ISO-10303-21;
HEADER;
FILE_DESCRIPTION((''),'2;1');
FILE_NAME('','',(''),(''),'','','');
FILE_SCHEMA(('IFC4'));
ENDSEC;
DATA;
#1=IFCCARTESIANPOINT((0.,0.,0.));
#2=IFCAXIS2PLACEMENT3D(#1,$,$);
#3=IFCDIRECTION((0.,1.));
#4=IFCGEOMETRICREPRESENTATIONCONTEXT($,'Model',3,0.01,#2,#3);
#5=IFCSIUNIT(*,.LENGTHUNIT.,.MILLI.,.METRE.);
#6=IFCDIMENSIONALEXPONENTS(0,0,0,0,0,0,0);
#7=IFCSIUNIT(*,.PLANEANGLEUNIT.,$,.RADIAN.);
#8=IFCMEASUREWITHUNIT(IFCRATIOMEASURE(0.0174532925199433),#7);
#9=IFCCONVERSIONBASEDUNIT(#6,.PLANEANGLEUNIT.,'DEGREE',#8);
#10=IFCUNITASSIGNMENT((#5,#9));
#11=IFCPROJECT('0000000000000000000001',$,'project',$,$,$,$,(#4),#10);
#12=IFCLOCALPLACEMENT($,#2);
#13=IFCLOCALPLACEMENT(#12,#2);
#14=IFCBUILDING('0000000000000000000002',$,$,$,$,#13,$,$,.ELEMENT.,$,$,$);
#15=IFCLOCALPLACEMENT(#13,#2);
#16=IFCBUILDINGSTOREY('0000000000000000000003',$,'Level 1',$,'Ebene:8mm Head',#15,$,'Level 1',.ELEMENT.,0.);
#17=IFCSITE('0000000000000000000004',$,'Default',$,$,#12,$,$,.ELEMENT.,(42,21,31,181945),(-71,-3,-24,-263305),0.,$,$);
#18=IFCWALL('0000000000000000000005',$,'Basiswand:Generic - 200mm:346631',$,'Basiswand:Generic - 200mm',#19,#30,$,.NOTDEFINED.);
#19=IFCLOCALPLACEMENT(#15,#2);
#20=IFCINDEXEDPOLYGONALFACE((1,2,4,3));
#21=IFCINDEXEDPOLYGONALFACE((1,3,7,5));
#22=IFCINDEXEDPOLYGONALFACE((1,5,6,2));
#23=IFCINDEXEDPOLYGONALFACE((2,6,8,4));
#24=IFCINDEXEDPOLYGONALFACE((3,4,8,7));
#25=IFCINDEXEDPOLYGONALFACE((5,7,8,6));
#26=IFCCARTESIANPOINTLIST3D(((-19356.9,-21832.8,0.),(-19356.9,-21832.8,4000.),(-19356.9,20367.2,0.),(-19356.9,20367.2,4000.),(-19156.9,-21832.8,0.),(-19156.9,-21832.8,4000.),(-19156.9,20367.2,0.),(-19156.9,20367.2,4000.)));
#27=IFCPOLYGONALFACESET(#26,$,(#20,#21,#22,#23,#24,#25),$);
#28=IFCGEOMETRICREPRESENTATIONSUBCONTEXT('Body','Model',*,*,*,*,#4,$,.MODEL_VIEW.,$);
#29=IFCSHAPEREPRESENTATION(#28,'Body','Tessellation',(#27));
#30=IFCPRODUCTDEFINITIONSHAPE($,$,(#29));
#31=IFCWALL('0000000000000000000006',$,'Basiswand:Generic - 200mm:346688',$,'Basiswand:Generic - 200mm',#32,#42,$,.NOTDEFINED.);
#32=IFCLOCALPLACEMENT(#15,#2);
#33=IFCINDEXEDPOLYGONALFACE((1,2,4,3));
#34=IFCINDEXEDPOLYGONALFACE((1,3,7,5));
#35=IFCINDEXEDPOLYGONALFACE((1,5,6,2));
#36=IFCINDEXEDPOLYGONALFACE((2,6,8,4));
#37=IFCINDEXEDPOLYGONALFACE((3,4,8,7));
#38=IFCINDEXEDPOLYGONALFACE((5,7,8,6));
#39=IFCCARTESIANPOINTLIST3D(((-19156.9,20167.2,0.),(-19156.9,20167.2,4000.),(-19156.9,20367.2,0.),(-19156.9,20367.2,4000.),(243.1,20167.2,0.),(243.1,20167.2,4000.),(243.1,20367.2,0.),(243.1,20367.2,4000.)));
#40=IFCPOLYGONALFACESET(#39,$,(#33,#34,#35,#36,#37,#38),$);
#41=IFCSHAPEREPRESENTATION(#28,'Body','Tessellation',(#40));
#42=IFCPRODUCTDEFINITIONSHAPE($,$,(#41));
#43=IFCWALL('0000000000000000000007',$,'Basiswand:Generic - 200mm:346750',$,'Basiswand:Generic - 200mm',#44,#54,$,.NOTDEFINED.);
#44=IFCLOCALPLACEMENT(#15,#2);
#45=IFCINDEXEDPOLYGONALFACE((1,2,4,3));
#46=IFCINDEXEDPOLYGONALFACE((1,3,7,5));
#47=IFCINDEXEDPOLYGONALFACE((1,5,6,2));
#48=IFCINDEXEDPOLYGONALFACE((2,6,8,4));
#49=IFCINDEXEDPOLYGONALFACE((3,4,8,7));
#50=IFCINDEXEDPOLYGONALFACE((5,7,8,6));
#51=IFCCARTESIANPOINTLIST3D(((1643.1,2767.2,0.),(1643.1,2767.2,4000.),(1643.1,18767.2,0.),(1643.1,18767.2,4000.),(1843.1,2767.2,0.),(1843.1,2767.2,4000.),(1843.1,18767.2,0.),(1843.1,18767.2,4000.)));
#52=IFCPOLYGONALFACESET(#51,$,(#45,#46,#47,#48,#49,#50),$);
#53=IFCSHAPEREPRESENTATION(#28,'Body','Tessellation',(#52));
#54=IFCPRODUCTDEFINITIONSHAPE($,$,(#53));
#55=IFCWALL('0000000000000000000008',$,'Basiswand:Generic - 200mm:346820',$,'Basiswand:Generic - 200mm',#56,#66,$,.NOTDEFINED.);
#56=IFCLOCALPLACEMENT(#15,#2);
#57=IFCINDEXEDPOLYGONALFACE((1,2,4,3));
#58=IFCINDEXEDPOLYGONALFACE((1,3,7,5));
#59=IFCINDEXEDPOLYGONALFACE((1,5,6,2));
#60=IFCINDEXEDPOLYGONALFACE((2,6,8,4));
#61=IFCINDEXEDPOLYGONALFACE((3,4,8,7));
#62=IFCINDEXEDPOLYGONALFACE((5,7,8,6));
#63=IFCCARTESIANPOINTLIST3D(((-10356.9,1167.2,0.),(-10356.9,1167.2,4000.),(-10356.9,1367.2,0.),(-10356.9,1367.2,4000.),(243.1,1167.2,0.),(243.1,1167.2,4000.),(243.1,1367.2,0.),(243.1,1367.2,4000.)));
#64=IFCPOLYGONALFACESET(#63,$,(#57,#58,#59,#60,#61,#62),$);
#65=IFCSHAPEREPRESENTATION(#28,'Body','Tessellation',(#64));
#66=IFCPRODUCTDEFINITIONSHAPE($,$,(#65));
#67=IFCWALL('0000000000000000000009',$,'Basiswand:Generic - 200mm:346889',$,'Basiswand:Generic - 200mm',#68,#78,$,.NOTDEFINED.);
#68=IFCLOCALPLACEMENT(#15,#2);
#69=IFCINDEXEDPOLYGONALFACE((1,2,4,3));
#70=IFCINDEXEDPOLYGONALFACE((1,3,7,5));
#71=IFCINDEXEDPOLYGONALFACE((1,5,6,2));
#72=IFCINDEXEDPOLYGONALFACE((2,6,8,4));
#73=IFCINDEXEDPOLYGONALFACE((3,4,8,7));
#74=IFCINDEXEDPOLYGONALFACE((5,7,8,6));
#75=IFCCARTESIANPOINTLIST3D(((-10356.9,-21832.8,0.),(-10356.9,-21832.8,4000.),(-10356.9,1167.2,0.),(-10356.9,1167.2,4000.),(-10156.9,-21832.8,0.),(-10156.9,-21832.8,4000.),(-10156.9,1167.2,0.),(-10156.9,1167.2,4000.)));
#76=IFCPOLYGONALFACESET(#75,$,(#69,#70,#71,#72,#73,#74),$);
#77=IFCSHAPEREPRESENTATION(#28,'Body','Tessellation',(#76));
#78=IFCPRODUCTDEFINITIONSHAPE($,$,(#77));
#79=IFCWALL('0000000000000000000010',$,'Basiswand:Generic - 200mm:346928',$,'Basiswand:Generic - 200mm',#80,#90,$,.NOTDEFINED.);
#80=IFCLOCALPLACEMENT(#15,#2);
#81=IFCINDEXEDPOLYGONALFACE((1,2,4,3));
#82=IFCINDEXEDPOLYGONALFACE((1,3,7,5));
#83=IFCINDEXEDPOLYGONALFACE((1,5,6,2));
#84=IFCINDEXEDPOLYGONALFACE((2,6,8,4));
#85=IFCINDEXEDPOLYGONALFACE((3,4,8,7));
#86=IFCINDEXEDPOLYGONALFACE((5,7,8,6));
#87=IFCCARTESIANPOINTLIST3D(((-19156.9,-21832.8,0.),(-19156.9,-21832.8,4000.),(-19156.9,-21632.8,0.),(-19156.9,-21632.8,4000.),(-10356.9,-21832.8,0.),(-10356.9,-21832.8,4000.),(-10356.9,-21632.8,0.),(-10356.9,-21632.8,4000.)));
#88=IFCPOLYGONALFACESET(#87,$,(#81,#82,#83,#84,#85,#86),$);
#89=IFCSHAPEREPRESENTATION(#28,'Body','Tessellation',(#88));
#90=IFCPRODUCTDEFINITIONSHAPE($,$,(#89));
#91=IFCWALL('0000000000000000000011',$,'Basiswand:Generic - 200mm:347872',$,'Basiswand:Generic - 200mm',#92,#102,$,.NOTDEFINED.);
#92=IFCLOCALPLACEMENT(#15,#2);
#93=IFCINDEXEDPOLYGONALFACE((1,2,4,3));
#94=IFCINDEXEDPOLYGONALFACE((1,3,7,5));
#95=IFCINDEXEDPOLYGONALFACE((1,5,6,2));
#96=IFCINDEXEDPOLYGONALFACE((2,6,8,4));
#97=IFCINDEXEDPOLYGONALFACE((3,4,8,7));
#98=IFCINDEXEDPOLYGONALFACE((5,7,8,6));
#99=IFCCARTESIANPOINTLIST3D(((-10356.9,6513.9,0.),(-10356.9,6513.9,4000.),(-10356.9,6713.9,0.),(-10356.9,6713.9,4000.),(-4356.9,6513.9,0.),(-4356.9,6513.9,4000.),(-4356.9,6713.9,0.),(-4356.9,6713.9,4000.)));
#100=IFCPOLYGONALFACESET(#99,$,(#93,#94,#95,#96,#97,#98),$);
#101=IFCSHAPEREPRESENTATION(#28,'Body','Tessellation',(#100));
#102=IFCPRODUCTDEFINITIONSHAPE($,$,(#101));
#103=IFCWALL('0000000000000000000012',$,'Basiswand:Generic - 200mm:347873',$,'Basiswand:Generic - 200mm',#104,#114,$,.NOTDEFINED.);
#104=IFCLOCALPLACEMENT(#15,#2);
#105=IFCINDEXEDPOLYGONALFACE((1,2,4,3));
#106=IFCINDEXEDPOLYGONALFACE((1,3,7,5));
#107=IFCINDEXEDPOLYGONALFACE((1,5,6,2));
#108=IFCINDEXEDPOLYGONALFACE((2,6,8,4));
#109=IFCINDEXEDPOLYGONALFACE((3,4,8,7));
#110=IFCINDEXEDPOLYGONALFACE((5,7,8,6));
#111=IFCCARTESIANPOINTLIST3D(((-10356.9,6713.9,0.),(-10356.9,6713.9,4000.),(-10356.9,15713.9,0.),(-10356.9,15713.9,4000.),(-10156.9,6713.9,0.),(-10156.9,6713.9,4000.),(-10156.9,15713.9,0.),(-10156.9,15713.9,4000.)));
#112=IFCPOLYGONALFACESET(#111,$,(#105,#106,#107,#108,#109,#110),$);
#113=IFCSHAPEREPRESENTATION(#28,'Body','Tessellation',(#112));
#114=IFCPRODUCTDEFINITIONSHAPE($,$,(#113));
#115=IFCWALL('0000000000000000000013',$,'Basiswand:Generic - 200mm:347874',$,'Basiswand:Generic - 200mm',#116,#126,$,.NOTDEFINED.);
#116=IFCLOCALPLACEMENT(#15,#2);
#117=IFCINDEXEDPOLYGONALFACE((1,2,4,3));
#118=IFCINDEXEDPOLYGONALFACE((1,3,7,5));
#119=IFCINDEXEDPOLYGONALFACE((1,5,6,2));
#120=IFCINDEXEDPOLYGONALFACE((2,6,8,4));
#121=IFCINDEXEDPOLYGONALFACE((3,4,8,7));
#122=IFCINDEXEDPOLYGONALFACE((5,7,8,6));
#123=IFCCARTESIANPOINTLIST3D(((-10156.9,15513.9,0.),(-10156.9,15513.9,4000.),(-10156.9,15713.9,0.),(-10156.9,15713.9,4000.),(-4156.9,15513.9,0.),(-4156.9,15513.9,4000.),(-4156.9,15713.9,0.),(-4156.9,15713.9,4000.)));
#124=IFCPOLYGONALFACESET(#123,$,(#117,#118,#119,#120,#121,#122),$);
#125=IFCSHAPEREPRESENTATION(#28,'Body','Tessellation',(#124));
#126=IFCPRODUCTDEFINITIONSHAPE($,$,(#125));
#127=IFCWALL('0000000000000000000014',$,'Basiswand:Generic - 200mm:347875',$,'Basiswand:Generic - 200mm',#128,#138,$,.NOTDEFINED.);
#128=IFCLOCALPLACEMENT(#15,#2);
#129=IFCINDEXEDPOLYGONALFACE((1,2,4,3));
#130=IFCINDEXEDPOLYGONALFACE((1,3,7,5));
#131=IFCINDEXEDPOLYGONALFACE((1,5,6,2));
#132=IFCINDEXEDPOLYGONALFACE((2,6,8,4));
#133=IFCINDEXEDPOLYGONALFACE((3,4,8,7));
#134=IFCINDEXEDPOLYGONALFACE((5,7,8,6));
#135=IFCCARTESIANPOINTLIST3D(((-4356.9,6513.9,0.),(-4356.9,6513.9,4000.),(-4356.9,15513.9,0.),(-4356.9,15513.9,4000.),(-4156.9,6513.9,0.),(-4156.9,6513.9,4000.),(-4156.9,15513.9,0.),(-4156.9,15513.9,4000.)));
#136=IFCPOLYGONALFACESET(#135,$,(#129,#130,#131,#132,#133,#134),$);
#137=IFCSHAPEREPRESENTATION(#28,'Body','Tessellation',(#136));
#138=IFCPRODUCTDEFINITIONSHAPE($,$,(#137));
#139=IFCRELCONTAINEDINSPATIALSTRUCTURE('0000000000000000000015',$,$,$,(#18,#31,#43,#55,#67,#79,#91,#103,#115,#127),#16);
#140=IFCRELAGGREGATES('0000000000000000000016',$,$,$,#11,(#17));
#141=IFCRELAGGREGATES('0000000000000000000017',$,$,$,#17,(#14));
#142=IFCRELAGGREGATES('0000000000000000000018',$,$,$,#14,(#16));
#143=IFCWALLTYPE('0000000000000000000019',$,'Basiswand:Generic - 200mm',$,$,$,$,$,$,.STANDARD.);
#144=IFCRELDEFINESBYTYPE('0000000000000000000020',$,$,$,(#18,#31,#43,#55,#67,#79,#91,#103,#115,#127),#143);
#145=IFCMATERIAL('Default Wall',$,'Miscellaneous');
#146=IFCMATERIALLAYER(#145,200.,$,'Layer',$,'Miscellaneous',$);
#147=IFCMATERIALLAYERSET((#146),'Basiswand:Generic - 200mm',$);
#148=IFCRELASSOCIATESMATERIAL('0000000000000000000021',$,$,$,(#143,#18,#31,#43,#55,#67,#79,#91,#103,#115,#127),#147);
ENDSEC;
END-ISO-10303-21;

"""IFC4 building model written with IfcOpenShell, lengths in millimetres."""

from ifc_helpers import new_model, entity, si_unit, converted_unit, direction, frame, frame_2d, origin, place, context, subcontext, project, spatial, rectangle, extrude, material, layer, layer_set, layer_usage, type_object, element, save


model = new_model("IFC4")

# Units and contexts
model_context = context("Model", 3, precision=0.01, world=origin(), true_north=direction((0.0, 1.0)))
body_context = subcontext(model_context, "Body", "Model", "MODEL_VIEW")
ifc_project = project(units=[si_unit("LENGTHUNIT", "METRE", prefix="MILLI"), converted_unit("PLANEANGLEUNIT", "DEGREE", entity("IfcRatioMeasure", 0.0174532925199433), si_unit("PLANEANGLEUNIT", "RADIAN"), dimensions=[0, 0, 0, 0, 0, 0, 0])], contexts=[model_context])

# Site, building, storey
site_placement = place(None, origin())
site = spatial("IfcSite", under=ifc_project, at=site_placement, Name="Default", CompositionType="ELEMENT", RefLatitude=(42, 21, 31, 181945), RefLongitude=(-71, -3, -24, -263305), RefElevation=0.0)
building_placement = place(site_placement, origin())
building = spatial("IfcBuilding", under=site, at=building_placement, CompositionType="ELEMENT")
storey_placement = place(building_placement, origin())
storey = spatial("IfcBuildingStorey", under=building, at=storey_placement, Name="Level 1", ObjectType="Ebene:8mm Head", LongName="Level 1", CompositionType="ELEMENT", Elevation=0.0)

# Walls
ifc_material = material(Name="Default Wall", Category="Miscellaneous")
ifc_layer = layer(ifc_material, 200.0, Name="Layer", Category="Miscellaneous")
ifc_layer_set = layer_set([ifc_layer], Name="Basiswand:Generic - 200mm")
ifc_layer_usage_1 = layer_usage(ifc_layer_set, "AXIS2", "NEGATIVE", 100.0)
wall_type = type_object("IfcWallType", Name="Basiswand:Generic - 200mm", PredefinedType="STANDARD", material=ifc_layer_set)
wall_1_placement = place(storey_placement, frame((-19256.9, -21832.8, 0.0), z_axis=(0.0, 0.0, 1.0), x_axis=(0.0, 1.0, 0.0)))
element("IfcWall", 1, at=wall_1_placement, inside=storey, type_object=wall_type, material=ifc_layer_usage_1, Name="Basiswand:Generic - 200mm:346631", ObjectType="Basiswand:Generic - 200mm", PredefinedType="NOTDEFINED", context=body_context, shape_type="SweptSolid", body=[
    extrude(rectangle(XDim=42200.0, YDim=200.0, at=frame_2d((21100.0, 0.0), x_axis=(-1.0, 0.0))), origin(), (0.0, 0.0, 1.0), 4000.0),
])
ifc_layer_usage_2 = layer_usage(ifc_layer_set, "AXIS2", "NEGATIVE", 100.0)
wall_2_placement = place(storey_placement, frame((-19156.9, 20267.2, 0.0)))
element("IfcWall", 2, at=wall_2_placement, inside=storey, type_object=wall_type, material=ifc_layer_usage_2, Name="Basiswand:Generic - 200mm:346688", ObjectType="Basiswand:Generic - 200mm", PredefinedType="NOTDEFINED", context=body_context, shape_type="SweptSolid", body=[
    extrude(rectangle(XDim=19400.0, YDim=200.0, at=frame_2d((9700.0, 0.0), x_axis=(-1.0, 0.0))), origin(), (0.0, 0.0, 1.0), 4000.0),
])
ifc_layer_usage_3 = layer_usage(ifc_layer_set, "AXIS2", "NEGATIVE", 100.0)
wall_3_placement = place(storey_placement, frame((1743.1, 18767.2, 0.0), z_axis=(0.0, 0.0, 1.0), x_axis=(0.0, -1.0, 0.0)))
element("IfcWall", 3, at=wall_3_placement, inside=storey, type_object=wall_type, material=ifc_layer_usage_3, Name="Basiswand:Generic - 200mm:346750", ObjectType="Basiswand:Generic - 200mm", PredefinedType="NOTDEFINED", context=body_context, shape_type="SweptSolid", body=[
    extrude(rectangle(XDim=16000.0, YDim=200.0, at=frame_2d((8000.0, 0.0), x_axis=(-1.0, 0.0))), origin(), (0.0, 0.0, 1.0), 4000.0),
])
ifc_layer_usage_4 = layer_usage(ifc_layer_set, "AXIS2", "NEGATIVE", 100.0)
wall_4_placement = place(storey_placement, frame((243.1, 1267.2, 0.0), z_axis=(0.0, 0.0, 1.0), x_axis=(-1.0, 0.0, 0.0)))
element("IfcWall", 4, at=wall_4_placement, inside=storey, type_object=wall_type, material=ifc_layer_usage_4, Name="Basiswand:Generic - 200mm:346820", ObjectType="Basiswand:Generic - 200mm", PredefinedType="NOTDEFINED", context=body_context, shape_type="SweptSolid", body=[
    extrude(rectangle(XDim=10600.0, YDim=200.0, at=frame_2d((5300.0, 0.0), x_axis=(-1.0, 0.0))), origin(), (0.0, 0.0, 1.0), 4000.0),
])
ifc_layer_usage_5 = layer_usage(ifc_layer_set, "AXIS2", "NEGATIVE", 100.0)
wall_5_placement = place(storey_placement, frame((-10256.9, 1167.2, 0.0), z_axis=(0.0, 0.0, 1.0), x_axis=(0.0, -1.0, 0.0)))
element("IfcWall", 5, at=wall_5_placement, inside=storey, type_object=wall_type, material=ifc_layer_usage_5, Name="Basiswand:Generic - 200mm:346889", ObjectType="Basiswand:Generic - 200mm", PredefinedType="NOTDEFINED", context=body_context, shape_type="SweptSolid", body=[
    extrude(rectangle(XDim=23000.0, YDim=200.0, at=frame_2d((11500.0, 0.0), x_axis=(-1.0, 0.0))), origin(), (0.0, 0.0, 1.0), 4000.0),
])
ifc_layer_usage_6 = layer_usage(ifc_layer_set, "AXIS2", "NEGATIVE", 100.0)
wall_6_placement = place(storey_placement, frame((-10356.9, -21732.8, 0.0), z_axis=(0.0, 0.0, 1.0), x_axis=(-1.0, 0.0, 0.0)))
element("IfcWall", 6, at=wall_6_placement, inside=storey, type_object=wall_type, material=ifc_layer_usage_6, Name="Basiswand:Generic - 200mm:346928", ObjectType="Basiswand:Generic - 200mm", PredefinedType="NOTDEFINED", context=body_context, shape_type="SweptSolid", body=[
    extrude(rectangle(XDim=8800.0, YDim=200.0, at=frame_2d((4400.0, 0.0), x_axis=(-1.0, 0.0))), origin(), (0.0, 0.0, 1.0), 4000.0),
])
ifc_layer_usage_7 = layer_usage(ifc_layer_set, "AXIS2", "NEGATIVE", 100.0)
wall_7_placement = place(storey_placement, frame((-10356.9, 6613.9, 0.0)))
element("IfcWall", 7, at=wall_7_placement, inside=storey, type_object=wall_type, material=ifc_layer_usage_7, Name="Basiswand:Generic - 200mm:347872", ObjectType="Basiswand:Generic - 200mm", PredefinedType="NOTDEFINED", context=body_context, shape_type="SweptSolid", body=[
    extrude(rectangle(XDim=6000.0, YDim=200.0, at=frame_2d((3000.0, 0.0), x_axis=(-1.0, 0.0))), origin(), (0.0, 0.0, 1.0), 4000.0),
])
ifc_layer_usage_8 = layer_usage(ifc_layer_set, "AXIS2", "NEGATIVE", 100.0)
wall_8_placement = place(storey_placement, frame((-10256.9, 15713.9, 0.0), z_axis=(0.0, 0.0, 1.0), x_axis=(0.0, -1.0, 0.0)))
element("IfcWall", 8, at=wall_8_placement, inside=storey, type_object=wall_type, material=ifc_layer_usage_8, Name="Basiswand:Generic - 200mm:347873", ObjectType="Basiswand:Generic - 200mm", PredefinedType="NOTDEFINED", context=body_context, shape_type="SweptSolid", body=[
    extrude(rectangle(XDim=9000.0, YDim=200.0, at=frame_2d((4500.0, 0.0), x_axis=(-1.0, 0.0))), origin(), (0.0, 0.0, 1.0), 4000.0),
])
ifc_layer_usage_9 = layer_usage(ifc_layer_set, "AXIS2", "NEGATIVE", 100.0)
wall_9_placement = place(storey_placement, frame((-4156.9, 15613.9, 0.0), z_axis=(0.0, 0.0, 1.0), x_axis=(-1.0, 0.0, 0.0)))
element("IfcWall", 9, at=wall_9_placement, inside=storey, type_object=wall_type, material=ifc_layer_usage_9, Name="Basiswand:Generic - 200mm:347874", ObjectType="Basiswand:Generic - 200mm", PredefinedType="NOTDEFINED", context=body_context, shape_type="SweptSolid", body=[
    extrude(rectangle(XDim=6000.0, YDim=200.0, at=frame_2d((3000.0, 0.0), x_axis=(-1.0, 0.0))), origin(), (0.0, 0.0, 1.0), 4000.0),
])
ifc_layer_usage_10 = layer_usage(ifc_layer_set, "AXIS2", "NEGATIVE", 100.0)
wall_10_placement = place(storey_placement, frame((-4256.9, 6513.9, 0.0), z_axis=(0.0, 0.0, 1.0), x_axis=(0.0, 1.0, 0.0)))
element("IfcWall", 10, at=wall_10_placement, inside=storey, type_object=wall_type, material=ifc_layer_usage_10, Name="Basiswand:Generic - 200mm:347875", ObjectType="Basiswand:Generic - 200mm", PredefinedType="NOTDEFINED", context=body_context, shape_type="SweptSolid", body=[
    extrude(rectangle(XDim=9000.0, YDim=200.0, at=frame_2d((4500.0, 0.0), x_axis=(-1.0, 0.0))), origin(), (0.0, 0.0, 1.0), 4000.0),
])

save(model, "model.ifc")
